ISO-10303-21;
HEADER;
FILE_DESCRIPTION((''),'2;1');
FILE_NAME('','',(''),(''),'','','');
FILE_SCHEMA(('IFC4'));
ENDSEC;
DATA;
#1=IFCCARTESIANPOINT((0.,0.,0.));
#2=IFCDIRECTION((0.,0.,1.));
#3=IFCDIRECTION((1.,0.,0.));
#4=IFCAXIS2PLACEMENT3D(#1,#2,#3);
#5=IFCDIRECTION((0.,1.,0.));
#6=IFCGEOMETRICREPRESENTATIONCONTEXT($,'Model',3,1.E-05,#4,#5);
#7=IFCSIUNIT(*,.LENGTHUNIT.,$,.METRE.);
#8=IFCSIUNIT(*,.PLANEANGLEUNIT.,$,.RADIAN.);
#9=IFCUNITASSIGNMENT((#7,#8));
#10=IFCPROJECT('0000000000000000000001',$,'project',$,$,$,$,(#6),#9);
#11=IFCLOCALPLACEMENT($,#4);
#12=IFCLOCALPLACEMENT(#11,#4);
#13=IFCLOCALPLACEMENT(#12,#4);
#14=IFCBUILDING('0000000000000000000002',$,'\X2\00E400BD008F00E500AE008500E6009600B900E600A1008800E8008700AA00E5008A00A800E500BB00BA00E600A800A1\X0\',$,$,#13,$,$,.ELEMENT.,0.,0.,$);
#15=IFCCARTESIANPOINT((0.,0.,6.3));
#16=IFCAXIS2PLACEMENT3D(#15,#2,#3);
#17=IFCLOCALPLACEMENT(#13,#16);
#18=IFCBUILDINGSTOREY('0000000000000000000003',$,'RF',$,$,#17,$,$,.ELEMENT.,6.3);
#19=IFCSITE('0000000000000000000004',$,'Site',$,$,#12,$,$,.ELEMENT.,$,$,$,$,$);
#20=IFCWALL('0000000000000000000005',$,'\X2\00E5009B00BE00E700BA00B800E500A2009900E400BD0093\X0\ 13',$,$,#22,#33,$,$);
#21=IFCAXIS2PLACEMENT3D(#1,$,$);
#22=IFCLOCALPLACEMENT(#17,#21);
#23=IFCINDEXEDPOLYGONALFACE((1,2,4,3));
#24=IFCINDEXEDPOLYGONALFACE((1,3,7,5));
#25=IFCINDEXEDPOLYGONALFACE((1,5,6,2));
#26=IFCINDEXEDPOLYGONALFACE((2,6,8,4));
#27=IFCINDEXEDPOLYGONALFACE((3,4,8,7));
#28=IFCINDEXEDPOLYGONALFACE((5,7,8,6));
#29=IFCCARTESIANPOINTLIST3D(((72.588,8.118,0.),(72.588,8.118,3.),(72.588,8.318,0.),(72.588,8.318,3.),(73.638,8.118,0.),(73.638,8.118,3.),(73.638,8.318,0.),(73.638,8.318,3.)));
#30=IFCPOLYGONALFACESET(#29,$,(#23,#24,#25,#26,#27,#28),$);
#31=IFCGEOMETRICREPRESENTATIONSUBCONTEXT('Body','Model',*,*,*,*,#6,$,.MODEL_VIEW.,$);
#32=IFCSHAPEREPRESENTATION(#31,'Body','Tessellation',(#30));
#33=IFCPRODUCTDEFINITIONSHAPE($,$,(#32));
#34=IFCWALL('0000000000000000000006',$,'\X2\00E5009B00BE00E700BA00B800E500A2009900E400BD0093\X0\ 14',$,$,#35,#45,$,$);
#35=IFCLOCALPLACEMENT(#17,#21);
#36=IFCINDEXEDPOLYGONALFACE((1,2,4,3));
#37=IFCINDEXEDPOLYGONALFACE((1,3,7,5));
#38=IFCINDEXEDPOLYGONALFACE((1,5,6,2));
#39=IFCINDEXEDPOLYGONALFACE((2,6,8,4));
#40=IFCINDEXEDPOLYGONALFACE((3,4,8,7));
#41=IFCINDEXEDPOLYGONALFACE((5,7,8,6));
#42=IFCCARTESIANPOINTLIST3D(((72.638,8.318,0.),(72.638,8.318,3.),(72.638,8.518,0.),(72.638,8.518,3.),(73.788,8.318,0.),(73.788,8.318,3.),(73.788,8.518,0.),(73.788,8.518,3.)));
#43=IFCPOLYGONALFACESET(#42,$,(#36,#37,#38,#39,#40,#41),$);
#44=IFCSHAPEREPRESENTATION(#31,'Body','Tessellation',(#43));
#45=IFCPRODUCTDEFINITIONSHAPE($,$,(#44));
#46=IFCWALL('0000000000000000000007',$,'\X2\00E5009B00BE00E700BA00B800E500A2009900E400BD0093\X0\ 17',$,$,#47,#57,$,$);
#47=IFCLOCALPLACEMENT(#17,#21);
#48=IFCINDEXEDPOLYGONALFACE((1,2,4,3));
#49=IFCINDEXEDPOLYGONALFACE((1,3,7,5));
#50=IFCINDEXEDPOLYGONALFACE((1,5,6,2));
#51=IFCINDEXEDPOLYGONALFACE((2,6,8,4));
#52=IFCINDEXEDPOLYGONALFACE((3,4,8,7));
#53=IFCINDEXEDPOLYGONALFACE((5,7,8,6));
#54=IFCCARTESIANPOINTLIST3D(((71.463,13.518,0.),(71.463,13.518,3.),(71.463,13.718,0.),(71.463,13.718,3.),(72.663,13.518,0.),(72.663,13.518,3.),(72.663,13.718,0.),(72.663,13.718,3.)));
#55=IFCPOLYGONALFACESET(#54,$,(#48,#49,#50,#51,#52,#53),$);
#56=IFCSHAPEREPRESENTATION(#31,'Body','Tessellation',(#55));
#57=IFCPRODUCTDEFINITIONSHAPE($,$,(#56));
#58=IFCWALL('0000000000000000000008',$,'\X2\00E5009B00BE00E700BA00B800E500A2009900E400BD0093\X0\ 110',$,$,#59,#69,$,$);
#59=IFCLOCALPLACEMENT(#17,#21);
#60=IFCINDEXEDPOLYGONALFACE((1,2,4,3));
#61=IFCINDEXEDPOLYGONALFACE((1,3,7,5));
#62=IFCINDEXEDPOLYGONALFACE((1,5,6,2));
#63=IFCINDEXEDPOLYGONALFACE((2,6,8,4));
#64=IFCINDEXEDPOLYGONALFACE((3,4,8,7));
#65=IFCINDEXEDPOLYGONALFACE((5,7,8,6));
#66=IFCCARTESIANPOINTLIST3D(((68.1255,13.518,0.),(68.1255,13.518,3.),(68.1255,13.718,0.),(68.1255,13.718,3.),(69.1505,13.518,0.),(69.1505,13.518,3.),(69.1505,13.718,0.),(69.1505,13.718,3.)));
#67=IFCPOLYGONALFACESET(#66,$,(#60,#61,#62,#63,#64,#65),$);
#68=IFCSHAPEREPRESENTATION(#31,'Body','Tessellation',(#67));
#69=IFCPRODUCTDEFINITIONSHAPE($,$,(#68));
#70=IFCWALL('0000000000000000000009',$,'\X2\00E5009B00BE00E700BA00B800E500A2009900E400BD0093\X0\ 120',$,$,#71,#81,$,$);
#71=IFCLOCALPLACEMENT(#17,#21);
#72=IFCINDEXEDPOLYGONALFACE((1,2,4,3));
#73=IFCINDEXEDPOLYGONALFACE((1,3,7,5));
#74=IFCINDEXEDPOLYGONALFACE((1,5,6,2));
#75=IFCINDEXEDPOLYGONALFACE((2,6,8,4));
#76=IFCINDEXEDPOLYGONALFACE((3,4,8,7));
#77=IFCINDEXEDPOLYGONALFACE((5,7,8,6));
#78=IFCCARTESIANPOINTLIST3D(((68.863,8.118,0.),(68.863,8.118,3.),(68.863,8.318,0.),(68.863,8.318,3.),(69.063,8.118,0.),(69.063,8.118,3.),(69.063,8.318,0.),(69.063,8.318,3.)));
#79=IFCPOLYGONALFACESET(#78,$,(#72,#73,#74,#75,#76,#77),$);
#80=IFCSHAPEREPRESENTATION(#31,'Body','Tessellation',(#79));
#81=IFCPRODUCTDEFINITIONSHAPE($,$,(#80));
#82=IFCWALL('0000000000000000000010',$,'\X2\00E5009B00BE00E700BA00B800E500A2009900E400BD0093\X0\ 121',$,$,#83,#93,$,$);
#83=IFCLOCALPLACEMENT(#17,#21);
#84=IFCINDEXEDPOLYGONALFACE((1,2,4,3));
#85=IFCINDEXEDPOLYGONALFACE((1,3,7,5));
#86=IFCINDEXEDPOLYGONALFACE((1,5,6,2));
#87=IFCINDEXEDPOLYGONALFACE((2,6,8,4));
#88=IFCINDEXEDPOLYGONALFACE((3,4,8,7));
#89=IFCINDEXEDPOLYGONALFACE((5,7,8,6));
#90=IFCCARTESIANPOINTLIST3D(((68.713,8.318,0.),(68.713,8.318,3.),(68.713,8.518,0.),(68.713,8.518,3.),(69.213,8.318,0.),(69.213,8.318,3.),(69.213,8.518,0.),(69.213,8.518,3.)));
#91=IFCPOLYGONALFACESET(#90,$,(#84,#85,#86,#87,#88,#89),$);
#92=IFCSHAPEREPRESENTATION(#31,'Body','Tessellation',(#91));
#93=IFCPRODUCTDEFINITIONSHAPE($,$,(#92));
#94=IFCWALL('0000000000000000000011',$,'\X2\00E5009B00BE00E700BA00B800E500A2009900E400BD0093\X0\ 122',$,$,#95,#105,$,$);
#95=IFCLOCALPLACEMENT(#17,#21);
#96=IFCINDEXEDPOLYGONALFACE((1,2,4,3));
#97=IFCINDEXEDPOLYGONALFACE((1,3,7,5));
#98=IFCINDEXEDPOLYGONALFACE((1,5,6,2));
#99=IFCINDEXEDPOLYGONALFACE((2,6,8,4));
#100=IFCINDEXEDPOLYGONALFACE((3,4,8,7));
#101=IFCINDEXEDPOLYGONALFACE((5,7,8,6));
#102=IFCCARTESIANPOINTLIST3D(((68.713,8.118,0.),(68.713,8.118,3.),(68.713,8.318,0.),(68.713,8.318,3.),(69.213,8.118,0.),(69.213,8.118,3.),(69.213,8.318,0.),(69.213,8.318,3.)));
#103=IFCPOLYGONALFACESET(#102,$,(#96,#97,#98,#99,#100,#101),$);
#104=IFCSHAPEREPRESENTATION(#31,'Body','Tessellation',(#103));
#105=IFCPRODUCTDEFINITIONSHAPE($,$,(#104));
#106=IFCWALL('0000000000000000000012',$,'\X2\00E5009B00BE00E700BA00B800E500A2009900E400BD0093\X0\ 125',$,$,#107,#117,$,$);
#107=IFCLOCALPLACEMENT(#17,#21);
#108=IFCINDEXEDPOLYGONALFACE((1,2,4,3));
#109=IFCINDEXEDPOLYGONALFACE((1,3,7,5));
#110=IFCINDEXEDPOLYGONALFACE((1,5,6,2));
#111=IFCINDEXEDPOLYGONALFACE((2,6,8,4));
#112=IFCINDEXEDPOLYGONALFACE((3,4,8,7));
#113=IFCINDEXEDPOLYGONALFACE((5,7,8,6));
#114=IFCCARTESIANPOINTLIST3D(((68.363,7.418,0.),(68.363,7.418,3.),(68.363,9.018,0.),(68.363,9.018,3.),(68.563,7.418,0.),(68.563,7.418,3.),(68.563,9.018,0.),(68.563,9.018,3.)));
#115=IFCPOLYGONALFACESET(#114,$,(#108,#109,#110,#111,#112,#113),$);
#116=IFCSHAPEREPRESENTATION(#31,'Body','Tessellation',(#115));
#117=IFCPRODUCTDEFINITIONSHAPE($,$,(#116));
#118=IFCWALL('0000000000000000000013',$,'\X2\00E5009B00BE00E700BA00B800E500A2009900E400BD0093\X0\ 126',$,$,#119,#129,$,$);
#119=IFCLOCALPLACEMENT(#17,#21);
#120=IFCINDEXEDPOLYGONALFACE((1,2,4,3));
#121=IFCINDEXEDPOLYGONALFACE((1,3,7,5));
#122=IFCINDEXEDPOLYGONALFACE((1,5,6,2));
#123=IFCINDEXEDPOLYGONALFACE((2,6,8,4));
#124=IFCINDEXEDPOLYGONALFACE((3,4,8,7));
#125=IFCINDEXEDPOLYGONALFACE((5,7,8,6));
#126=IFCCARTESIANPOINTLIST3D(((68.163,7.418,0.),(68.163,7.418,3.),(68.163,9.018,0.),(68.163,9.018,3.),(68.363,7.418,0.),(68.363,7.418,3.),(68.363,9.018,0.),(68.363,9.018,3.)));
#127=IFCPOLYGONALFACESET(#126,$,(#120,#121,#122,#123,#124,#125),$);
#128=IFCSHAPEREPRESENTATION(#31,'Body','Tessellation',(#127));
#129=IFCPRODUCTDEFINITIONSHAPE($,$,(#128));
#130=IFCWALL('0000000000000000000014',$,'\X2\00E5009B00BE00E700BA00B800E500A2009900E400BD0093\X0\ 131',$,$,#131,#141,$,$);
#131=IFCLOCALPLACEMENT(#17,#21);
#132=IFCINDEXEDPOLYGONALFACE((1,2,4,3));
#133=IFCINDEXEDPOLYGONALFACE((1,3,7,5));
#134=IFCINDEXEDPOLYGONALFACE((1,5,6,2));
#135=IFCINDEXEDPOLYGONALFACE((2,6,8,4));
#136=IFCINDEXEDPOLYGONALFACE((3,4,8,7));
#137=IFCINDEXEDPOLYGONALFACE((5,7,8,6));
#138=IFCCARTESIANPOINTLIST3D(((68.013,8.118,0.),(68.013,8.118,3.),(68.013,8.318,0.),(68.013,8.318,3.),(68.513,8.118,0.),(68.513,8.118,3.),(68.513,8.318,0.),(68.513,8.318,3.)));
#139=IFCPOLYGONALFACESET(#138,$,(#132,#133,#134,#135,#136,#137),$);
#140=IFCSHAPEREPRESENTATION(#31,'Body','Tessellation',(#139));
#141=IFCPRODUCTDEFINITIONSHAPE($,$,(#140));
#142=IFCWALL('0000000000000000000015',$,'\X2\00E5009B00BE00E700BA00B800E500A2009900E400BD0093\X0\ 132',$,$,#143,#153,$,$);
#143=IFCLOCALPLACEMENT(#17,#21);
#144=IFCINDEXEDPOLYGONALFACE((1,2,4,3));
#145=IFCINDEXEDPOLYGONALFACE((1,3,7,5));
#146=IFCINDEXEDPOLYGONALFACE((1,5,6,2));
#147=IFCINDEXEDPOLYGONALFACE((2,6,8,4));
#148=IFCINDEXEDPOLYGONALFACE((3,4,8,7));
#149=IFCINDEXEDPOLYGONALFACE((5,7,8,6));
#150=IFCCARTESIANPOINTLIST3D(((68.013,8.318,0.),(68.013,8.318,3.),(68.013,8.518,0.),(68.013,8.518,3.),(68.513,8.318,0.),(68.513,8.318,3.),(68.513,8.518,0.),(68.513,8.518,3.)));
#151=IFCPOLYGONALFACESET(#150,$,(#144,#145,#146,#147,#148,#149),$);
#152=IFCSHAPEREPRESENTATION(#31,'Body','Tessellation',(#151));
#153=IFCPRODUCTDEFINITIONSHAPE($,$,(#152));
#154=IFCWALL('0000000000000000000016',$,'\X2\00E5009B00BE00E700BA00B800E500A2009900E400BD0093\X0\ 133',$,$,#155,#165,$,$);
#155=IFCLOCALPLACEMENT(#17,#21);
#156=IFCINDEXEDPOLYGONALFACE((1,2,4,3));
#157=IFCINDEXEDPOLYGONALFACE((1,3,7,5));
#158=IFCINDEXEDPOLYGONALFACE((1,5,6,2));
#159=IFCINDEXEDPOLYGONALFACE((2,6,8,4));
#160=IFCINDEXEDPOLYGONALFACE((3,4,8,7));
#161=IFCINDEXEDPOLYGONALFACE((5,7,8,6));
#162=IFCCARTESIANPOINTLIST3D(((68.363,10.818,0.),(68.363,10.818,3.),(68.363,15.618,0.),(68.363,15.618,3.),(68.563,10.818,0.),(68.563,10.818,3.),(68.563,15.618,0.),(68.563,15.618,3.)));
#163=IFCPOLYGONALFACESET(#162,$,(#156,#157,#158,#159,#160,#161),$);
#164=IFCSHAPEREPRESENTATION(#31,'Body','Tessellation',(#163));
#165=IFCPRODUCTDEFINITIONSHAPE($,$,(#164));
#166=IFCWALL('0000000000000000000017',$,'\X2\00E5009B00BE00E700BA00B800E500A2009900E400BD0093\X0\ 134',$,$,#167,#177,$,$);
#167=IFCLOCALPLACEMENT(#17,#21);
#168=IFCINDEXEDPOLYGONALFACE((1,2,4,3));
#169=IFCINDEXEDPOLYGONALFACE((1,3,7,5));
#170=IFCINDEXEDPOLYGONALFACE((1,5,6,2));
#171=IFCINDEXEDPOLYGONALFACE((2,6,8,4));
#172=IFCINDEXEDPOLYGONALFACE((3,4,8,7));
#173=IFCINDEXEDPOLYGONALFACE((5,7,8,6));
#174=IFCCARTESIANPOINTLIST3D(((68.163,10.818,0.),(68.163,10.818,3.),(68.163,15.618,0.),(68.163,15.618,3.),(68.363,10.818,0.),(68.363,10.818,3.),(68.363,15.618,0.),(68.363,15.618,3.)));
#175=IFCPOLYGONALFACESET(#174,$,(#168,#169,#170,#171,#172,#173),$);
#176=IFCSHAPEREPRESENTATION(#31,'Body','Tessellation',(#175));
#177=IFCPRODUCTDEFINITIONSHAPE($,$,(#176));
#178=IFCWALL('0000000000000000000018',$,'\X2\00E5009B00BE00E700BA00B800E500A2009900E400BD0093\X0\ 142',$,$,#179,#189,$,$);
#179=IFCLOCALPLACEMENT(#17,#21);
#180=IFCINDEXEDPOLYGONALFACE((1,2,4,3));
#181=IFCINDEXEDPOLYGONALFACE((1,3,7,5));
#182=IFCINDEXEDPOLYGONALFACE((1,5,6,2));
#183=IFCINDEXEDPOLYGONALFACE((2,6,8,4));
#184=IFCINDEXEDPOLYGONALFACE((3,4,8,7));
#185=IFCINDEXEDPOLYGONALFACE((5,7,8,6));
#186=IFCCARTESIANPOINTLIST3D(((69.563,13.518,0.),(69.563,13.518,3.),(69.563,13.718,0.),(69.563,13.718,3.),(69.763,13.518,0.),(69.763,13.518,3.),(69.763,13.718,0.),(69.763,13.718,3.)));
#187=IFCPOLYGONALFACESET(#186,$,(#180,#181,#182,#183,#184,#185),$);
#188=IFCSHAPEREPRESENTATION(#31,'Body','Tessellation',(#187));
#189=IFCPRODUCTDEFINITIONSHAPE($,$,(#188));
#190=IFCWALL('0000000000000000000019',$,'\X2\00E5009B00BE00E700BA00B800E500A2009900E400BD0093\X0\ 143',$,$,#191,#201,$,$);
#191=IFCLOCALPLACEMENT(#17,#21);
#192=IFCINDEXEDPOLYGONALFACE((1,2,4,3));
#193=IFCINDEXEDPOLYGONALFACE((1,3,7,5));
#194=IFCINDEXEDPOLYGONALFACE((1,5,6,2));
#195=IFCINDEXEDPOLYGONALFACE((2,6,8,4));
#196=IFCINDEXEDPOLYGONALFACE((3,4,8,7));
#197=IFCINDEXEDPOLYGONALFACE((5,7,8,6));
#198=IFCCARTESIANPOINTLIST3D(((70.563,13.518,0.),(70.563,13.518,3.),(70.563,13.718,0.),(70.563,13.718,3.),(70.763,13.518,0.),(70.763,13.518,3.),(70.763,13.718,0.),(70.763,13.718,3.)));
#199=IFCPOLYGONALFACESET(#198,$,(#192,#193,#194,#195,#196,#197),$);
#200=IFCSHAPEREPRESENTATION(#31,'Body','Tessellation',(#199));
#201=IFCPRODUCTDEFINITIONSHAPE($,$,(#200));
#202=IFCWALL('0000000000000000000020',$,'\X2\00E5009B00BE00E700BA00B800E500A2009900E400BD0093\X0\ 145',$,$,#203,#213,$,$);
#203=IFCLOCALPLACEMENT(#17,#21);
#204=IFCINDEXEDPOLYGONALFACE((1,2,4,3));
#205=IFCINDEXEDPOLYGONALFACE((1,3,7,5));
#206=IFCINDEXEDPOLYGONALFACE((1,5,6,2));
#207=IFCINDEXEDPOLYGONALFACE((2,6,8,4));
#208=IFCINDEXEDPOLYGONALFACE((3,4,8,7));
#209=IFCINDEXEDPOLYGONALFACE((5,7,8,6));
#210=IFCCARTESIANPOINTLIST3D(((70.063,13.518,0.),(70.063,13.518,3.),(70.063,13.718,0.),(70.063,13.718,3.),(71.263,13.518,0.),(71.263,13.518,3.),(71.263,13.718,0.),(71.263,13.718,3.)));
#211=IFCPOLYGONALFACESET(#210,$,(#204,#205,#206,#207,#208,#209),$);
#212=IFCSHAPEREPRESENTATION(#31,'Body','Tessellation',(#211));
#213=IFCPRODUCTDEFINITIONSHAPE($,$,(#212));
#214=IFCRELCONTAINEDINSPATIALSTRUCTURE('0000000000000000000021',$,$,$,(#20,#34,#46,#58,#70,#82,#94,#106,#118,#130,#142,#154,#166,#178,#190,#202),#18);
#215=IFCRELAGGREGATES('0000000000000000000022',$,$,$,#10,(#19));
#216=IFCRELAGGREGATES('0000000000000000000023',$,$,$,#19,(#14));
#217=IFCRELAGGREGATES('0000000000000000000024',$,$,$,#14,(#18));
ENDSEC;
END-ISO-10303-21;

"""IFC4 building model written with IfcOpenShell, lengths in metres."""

from ifc_helpers import new_model, si_unit, direction, frame, frame_2d, origin_with_axes, place, context, subcontext, project, spatial, rectangle, extrude, element, save


model = new_model("IFC4")

# Units and contexts
model_context = context("Model", 3, precision=1e-05, world=origin_with_axes(), true_north=direction((0.0, 1.0, 0.0)))
body_context = subcontext(model_context, "Body", "Model", "MODEL_VIEW")
ifc_project = project(units=[si_unit("LENGTHUNIT", "METRE"), si_unit("PLANEANGLEUNIT", "RADIAN")], contexts=[model_context])

# Site, building, storey
placement = place(None, origin_with_axes())
site_placement = place(placement, origin_with_axes())
site = spatial("IfcSite", under=ifc_project, at=site_placement, Name="Site", CompositionType="ELEMENT")
building_placement = place(site_placement, origin_with_axes())
building = spatial("IfcBuilding", under=site, at=building_placement, Name="ä½\u008få®\u0085æ\u0096¹æ¡\u0088è\u0087ªå\u008a¨å»ºæ¨¡", CompositionType="ELEMENT", ElevationOfRefHeight=0.0, ElevationOfTerrain=0.0)
storey_placement = place(building_placement, frame((0.0, 0.0, 6.3), z_axis=(0.0, 0.0, 1.0), x_axis=(1.0, 0.0, 0.0)))
storey = spatial("IfcBuildingStorey", under=building, at=storey_placement, Name="RF", CompositionType="ELEMENT", Elevation=6.3)

# Walls
wall_1_placement = place(storey_placement, frame((73.113, 8.218, 0.0), z_axis=(0.0, 0.0, 1.0), x_axis=(-1.0, 0.0, 0.0)))
element("IfcWall", 1, at=wall_1_placement, inside=storey, Name="å\u009b¾çº¸å¢\u0099ä½\u0093 13", context=body_context, shape_type="SweptSolid", body=[
    extrude(rectangle(XDim=1.05, YDim=0.2, at=frame_2d((0.0, 0.0), x_axis=(1.0, 0.0, 0.0))), frame((0.0, 0.0, 0.0), z_axis=(0.0, 0.0, 1.0)), (0.0, 0.0, 1.0), 3.0),
])
wall_2_placement = place(storey_placement, frame((73.213, 8.418, 0.0), z_axis=(0.0, 0.0, 1.0), x_axis=(-1.0, 0.0, 0.0)))
element("IfcWall", 2, at=wall_2_placement, inside=storey, Name="å\u009b¾çº¸å¢\u0099ä½\u0093 14", context=body_context, shape_type="SweptSolid", body=[
    extrude(rectangle(XDim=1.15, YDim=0.2, at=frame_2d((0.0, 0.0), x_axis=(1.0, 0.0, 0.0))), frame((0.0, 0.0, 0.0), z_axis=(0.0, 0.0, 1.0)), (0.0, 0.0, 1.0), 3.0),
])
wall_3_placement = place(storey_placement, frame((72.063, 13.618, 0.0), z_axis=(0.0, 0.0, 1.0), x_axis=(1.0, 0.0, 0.0)))
element("IfcWall", 3, at=wall_3_placement, inside=storey, Name="å\u009b¾çº¸å¢\u0099ä½\u0093 17", context=body_context, shape_type="SweptSolid", body=[
    extrude(rectangle(XDim=1.2, YDim=0.2, at=frame_2d((0.0, 0.0), x_axis=(1.0, 0.0, 0.0))), frame((0.0, 0.0, 0.0), z_axis=(0.0, 0.0, 1.0)), (0.0, 0.0, 1.0), 3.0),
])
wall_4_placement = place(storey_placement, frame((68.638, 13.618, 0.0), z_axis=(0.0, 0.0, 1.0), x_axis=(1.0, 0.0, 0.0)))
element("IfcWall", 4, at=wall_4_placement, inside=storey, Name="å\u009b¾çº¸å¢\u0099ä½\u0093 110", context=body_context, shape_type="SweptSolid", body=[
    extrude(rectangle(XDim=1.025, YDim=0.2, at=frame_2d((0.0, 0.0), x_axis=(1.0, 0.0, 0.0))), frame((0.0, 0.0, 0.0), z_axis=(0.0, 0.0, 1.0)), (0.0, 0.0, 1.0), 3.0),
])
wall_5_placement = place(storey_placement, frame((68.963, 8.218, 0.0), z_axis=(0.0, 0.0, 1.0), x_axis=(0.0, 1.0, 0.0)))
element("IfcWall", 5, at=wall_5_placement, inside=storey, Name="å\u009b¾çº¸å¢\u0099ä½\u0093 120", context=body_context, shape_type="SweptSolid", body=[
    extrude(rectangle(XDim=0.2, YDim=0.2, at=frame_2d((0.0, 0.0), x_axis=(1.0, 0.0, 0.0))), frame((0.0, 0.0, 0.0), z_axis=(0.0, 0.0, 1.0)), (0.0, 0.0, 1.0), 3.0),
])
for number, where, z_axis, x_axis, name in (
    (6, (68.963, 8.418, 0.0), (0.0, 0.0, 1.0), (-1.0, 0.0, 0.0), "å\u009b¾çº¸å¢\u0099ä½\u0093 121"),
    (7, (68.963, 8.218, 0.0), (0.0, 0.0, 1.0), (-1.0, 0.0, 0.0), "å\u009b¾çº¸å¢\u0099ä½\u0093 122"),
):
    element("IfcWall", number, at=place(storey_placement, frame(where, z_axis=z_axis, x_axis=x_axis)), inside=storey, Name=name, context=body_context, shape_type="SweptSolid", body=[
        extrude(rectangle(XDim=0.5, YDim=0.2, at=frame_2d((0.0, 0.0), x_axis=(1.0, 0.0, 0.0))), frame((0.0, 0.0, 0.0), z_axis=(0.0, 0.0, 1.0)), (0.0, 0.0, 1.0), 3.0),
    ])
for number, where, z_axis, x_axis, name in (
    (8, (68.463, 8.218, 0.0), (0.0, 0.0, 1.0), (0.0, -1.0, 0.0), "å\u009b¾çº¸å¢\u0099ä½\u0093 125"),
    (9, (68.263, 8.218, 0.0), (0.0, 0.0, 1.0), (0.0, -1.0, 0.0), "å\u009b¾çº¸å¢\u0099ä½\u0093 126"),
):
    element("IfcWall", number, at=place(storey_placement, frame(where, z_axis=z_axis, x_axis=x_axis)), inside=storey, Name=name, context=body_context, shape_type="SweptSolid", body=[
        extrude(rectangle(XDim=1.6, YDim=0.2, at=frame_2d((0.0, 0.0), x_axis=(1.0, 0.0, 0.0))), frame((0.0, 0.0, 0.0), z_axis=(0.0, 0.0, 1.0)), (0.0, 0.0, 1.0), 3.0),
    ])
for number, where, z_axis, x_axis, name in (
    (10, (68.263, 8.218, 0.0), (0.0, 0.0, 1.0), (-1.0, 0.0, 0.0), "å\u009b¾çº¸å¢\u0099ä½\u0093 131"),
    (11, (68.263, 8.418, 0.0), (0.0, 0.0, 1.0), (-1.0, 0.0, 0.0), "å\u009b¾çº¸å¢\u0099ä½\u0093 132"),
):
    element("IfcWall", number, at=place(storey_placement, frame(where, z_axis=z_axis, x_axis=x_axis)), inside=storey, Name=name, context=body_context, shape_type="SweptSolid", body=[
        extrude(rectangle(XDim=0.5, YDim=0.2, at=frame_2d((0.0, 0.0), x_axis=(1.0, 0.0, 0.0))), frame((0.0, 0.0, 0.0), z_axis=(0.0, 0.0, 1.0)), (0.0, 0.0, 1.0), 3.0),
    ])
for number, where, z_axis, x_axis, name in (
    (12, (68.463, 13.218, 0.0), (0.0, 0.0, 1.0), (0.0, -1.0, 0.0), "å\u009b¾çº¸å¢\u0099ä½\u0093 133"),
    (13, (68.263, 13.218, 0.0), (0.0, 0.0, 1.0), (0.0, -1.0, 0.0), "å\u009b¾çº¸å¢\u0099ä½\u0093 134"),
):
    element("IfcWall", number, at=place(storey_placement, frame(where, z_axis=z_axis, x_axis=x_axis)), inside=storey, Name=name, context=body_context, shape_type="SweptSolid", body=[
        extrude(rectangle(XDim=4.8, YDim=0.2, at=frame_2d((0.0, 0.0), x_axis=(1.0, 0.0, 0.0))), frame((0.0, 0.0, 0.0), z_axis=(0.0, 0.0, 1.0)), (0.0, 0.0, 1.0), 3.0),
    ])
for number, where, z_axis, x_axis, name in (
    (14, (69.663, 13.618, 0.0), (0.0, 0.0, 1.0), (0.0, 1.0, 0.0), "å\u009b¾çº¸å¢\u0099ä½\u0093 142"),
    (15, (70.663, 13.618, 0.0), (0.0, 0.0, 1.0), (0.0, 1.0, 0.0), "å\u009b¾çº¸å¢\u0099ä½\u0093 143"),
):
    element("IfcWall", number, at=place(storey_placement, frame(where, z_axis=z_axis, x_axis=x_axis)), inside=storey, Name=name, context=body_context, shape_type="SweptSolid", body=[
        extrude(rectangle(XDim=0.2, YDim=0.2, at=frame_2d((0.0, 0.0), x_axis=(1.0, 0.0, 0.0))), frame((0.0, 0.0, 0.0), z_axis=(0.0, 0.0, 1.0)), (0.0, 0.0, 1.0), 3.0),
    ])
wall_6_placement = place(storey_placement, frame((70.663, 13.618, 0.0), z_axis=(0.0, 0.0, 1.0), x_axis=(1.0, 0.0, 0.0)))
element("IfcWall", 16, at=wall_6_placement, inside=storey, Name="å\u009b¾çº¸å¢\u0099ä½\u0093 145", context=body_context, shape_type="SweptSolid", body=[
    extrude(rectangle(XDim=1.2, YDim=0.2, at=frame_2d((0.0, 0.0), x_axis=(1.0, 0.0, 0.0))), frame((0.0, 0.0, 0.0), z_axis=(0.0, 0.0, 1.0)), (0.0, 0.0, 1.0), 3.0),
])

save(model, "model.ifc")
